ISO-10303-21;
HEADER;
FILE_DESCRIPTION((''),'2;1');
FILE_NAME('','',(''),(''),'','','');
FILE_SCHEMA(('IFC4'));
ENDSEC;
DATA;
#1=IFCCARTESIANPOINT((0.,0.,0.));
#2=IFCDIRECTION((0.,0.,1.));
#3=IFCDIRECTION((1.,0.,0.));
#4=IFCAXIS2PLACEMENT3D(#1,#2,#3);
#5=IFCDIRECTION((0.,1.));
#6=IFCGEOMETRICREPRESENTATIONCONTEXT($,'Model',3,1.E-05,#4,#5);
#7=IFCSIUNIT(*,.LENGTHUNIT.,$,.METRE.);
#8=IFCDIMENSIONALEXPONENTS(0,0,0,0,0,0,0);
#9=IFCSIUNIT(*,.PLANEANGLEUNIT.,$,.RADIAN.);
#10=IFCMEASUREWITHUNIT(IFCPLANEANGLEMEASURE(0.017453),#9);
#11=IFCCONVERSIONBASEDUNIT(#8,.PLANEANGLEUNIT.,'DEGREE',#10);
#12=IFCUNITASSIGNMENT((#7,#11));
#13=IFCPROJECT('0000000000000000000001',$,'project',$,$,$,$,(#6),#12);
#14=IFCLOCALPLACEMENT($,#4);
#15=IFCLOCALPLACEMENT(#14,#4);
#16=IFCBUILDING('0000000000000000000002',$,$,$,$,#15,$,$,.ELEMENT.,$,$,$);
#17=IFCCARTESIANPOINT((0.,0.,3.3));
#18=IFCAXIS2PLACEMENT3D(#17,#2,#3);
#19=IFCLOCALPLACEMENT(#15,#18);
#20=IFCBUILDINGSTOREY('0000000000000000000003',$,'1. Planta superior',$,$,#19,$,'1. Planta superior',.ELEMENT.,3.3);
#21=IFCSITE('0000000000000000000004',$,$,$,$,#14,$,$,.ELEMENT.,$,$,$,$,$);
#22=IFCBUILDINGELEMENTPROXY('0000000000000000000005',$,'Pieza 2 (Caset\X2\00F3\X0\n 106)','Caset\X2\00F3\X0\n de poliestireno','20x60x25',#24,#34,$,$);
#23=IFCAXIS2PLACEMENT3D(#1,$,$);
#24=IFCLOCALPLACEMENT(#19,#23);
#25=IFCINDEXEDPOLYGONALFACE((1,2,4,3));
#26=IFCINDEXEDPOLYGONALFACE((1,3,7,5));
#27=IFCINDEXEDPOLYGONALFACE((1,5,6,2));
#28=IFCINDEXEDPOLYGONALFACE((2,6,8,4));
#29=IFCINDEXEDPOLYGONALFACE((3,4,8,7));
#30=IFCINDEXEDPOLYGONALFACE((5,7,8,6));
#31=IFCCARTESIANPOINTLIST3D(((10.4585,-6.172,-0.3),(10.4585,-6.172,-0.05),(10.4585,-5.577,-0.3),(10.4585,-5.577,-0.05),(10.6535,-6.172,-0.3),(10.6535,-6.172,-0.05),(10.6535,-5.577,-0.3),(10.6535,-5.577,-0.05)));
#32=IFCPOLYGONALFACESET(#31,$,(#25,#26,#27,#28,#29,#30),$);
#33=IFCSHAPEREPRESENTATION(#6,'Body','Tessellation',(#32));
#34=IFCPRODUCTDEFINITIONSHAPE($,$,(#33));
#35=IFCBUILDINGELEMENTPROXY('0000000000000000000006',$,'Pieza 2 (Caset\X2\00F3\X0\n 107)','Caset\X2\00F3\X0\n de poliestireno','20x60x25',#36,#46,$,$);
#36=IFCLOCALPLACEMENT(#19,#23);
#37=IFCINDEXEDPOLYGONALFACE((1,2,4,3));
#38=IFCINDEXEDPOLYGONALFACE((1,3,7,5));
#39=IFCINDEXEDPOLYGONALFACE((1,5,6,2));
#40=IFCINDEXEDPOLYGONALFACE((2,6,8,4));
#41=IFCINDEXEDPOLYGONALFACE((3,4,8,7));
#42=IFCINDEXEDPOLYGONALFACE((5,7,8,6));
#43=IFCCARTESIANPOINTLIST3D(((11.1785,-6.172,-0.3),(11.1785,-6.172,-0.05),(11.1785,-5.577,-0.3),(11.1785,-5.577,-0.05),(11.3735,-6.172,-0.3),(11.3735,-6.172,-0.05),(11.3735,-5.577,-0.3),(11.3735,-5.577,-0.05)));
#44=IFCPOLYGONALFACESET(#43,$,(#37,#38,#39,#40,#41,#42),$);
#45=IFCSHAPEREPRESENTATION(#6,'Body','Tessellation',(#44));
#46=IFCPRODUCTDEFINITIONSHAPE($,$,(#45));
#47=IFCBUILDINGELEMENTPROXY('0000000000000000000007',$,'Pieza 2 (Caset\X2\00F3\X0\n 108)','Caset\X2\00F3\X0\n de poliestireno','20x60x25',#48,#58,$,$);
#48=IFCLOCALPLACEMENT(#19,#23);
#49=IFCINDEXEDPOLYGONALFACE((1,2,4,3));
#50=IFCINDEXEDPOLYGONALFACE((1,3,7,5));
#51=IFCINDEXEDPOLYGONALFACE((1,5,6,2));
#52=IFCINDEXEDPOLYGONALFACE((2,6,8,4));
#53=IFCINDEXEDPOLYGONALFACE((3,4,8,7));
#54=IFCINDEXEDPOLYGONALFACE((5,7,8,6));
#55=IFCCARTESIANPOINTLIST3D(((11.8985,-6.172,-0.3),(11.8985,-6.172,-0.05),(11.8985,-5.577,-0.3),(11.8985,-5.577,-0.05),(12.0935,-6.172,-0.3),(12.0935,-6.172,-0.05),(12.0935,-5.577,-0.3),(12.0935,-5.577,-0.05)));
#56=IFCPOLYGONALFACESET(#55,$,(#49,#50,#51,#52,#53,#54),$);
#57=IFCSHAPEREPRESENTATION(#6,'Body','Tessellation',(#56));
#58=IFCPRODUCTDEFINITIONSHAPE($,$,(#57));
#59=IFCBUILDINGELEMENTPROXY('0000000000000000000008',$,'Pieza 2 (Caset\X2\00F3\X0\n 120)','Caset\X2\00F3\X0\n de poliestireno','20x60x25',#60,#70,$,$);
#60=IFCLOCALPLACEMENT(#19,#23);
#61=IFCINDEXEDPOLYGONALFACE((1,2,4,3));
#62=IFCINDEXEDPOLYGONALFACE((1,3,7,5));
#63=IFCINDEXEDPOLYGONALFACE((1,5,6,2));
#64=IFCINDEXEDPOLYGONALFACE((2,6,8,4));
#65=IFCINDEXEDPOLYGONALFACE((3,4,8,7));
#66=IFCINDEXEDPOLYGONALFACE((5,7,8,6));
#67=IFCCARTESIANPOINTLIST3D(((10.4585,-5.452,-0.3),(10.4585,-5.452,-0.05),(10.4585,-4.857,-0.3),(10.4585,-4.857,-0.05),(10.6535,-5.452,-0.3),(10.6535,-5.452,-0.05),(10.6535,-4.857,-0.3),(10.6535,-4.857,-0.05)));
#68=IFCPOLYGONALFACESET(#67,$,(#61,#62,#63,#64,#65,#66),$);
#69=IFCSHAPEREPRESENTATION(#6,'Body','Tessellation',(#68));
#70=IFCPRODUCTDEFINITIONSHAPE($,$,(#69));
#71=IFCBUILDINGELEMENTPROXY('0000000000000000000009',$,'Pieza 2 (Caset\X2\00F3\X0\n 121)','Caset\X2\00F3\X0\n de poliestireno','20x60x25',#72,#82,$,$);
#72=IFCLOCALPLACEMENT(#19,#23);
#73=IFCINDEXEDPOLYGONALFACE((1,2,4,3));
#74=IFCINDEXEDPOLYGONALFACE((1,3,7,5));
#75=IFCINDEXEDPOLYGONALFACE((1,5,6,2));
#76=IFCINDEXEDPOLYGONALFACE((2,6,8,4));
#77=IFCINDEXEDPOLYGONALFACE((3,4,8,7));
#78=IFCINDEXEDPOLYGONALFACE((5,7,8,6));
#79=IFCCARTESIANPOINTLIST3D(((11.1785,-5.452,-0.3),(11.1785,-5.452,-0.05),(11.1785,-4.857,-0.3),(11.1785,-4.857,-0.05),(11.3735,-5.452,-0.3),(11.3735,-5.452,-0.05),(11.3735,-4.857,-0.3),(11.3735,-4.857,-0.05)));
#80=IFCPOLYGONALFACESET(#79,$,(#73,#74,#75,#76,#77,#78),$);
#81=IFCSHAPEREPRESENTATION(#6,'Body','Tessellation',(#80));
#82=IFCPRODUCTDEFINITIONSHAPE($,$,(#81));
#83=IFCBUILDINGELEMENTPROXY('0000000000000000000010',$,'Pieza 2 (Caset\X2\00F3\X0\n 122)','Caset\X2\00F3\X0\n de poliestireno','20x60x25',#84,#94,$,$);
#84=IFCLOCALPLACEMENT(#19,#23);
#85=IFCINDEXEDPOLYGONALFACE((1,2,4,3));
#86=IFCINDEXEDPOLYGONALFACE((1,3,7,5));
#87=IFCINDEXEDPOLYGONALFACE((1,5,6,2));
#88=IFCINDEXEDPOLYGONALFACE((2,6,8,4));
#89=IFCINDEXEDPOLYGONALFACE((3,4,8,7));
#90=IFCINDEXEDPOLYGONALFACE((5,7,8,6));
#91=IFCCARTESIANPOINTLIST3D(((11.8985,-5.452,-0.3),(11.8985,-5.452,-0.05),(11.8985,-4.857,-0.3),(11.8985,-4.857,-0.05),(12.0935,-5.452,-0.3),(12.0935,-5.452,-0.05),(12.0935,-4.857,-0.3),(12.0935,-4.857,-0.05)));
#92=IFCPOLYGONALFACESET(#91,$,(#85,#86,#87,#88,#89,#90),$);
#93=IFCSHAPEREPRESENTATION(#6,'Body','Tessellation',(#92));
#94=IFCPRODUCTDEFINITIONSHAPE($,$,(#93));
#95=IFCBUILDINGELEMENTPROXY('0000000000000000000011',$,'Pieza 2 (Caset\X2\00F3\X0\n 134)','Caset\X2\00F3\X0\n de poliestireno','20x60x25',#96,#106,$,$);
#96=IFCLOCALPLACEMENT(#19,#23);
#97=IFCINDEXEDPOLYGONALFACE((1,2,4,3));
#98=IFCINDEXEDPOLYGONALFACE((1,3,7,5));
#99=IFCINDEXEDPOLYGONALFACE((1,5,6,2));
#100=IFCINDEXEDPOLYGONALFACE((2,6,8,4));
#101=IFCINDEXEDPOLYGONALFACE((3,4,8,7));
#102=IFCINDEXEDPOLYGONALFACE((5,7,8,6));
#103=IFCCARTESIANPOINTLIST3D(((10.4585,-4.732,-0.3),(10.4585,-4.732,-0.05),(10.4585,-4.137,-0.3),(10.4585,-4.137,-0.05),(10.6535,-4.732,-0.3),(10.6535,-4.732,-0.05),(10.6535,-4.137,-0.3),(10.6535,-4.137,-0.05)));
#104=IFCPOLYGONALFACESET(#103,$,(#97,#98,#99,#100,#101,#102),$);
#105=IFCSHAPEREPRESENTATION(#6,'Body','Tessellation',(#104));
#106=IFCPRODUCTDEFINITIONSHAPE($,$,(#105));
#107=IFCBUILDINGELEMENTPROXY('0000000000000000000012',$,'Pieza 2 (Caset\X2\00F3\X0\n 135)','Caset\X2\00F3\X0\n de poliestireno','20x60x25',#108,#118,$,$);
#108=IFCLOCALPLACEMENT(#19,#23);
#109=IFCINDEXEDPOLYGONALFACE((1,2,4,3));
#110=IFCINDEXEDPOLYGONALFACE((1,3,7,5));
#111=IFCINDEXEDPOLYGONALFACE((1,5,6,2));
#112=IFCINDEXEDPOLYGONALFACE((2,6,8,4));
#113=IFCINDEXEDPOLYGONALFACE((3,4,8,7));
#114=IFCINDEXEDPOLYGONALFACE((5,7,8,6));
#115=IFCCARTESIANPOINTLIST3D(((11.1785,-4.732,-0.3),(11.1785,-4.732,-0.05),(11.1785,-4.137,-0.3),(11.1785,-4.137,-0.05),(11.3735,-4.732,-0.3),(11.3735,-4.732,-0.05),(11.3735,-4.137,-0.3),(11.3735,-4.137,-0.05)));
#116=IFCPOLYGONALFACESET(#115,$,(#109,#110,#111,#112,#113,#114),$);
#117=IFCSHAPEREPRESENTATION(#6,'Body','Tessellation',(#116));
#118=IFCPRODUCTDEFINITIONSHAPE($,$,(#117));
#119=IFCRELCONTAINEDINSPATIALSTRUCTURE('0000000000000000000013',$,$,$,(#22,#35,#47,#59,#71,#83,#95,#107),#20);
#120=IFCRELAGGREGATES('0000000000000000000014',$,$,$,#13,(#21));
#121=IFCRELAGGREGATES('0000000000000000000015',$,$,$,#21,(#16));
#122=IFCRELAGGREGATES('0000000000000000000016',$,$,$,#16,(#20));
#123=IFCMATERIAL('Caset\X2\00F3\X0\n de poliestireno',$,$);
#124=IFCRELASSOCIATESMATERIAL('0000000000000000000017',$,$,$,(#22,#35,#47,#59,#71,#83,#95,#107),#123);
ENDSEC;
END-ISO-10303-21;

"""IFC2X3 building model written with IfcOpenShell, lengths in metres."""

from ifc_helpers import new_model, entity, si_unit, converted_unit, direction, frame, origin_with_axes, origin_2d_with_axis, place, context, project, spatial, rectangle, extrude, source, transform, mapped, material, element, save


model = new_model("IFC2X3")

# Units and contexts
model_context = context("Model", 3, precision=1e-05, world=origin_with_axes(), true_north=direction((0.0, 1.0)))
ifc_project = project(units=[si_unit("LENGTHUNIT", "METRE"), converted_unit("PLANEANGLEUNIT", "DEGREE", entity("IfcPlaneAngleMeasure", 0.017453), si_unit("PLANEANGLEUNIT", "RADIAN"), dimensions=[0, 0, 0, 0, 0, 0, 0])], contexts=[model_context])

# Site, building, storey
site_placement = place(None, origin_with_axes())
site = spatial("IfcSite", under=ifc_project, at=site_placement, CompositionType="ELEMENT")
building_placement = place(site_placement, origin_with_axes())
building = spatial("IfcBuilding", under=site, at=building_placement, CompositionType="ELEMENT")
storey_placement = place(building_placement, frame((0.0, 0.0, 3.3), z_axis=(0.0, 0.0, 1.0), x_axis=(1.0, 0.0, 0.0)))
storey = spatial("IfcBuildingStorey", under=building, at=storey_placement, Name="1. Planta superior", LongName="1. Planta superior", CompositionType="ELEMENT", Elevation=3.3)

# Building element proxies
ifc_material = material(Name="Casetón de poliestireno")
shared_shape = source(origin_with_axes(), model_context, "Body", "SweptSolid", [
    extrude(rectangle(XDim=0.195, YDim=0.25, at=origin_2d_with_axis()), origin_with_axes(), (0.0, 0.0, 1.0), 0.595),
])
placement_1 = place(storey_placement, frame((10.556, -6.172, -0.175), z_axis=(0.0, 1.0, 0.0), x_axis=(-1.0, 0.0, 0.0)))
for number, where, z_axis, x_axis, name in (
    (1, (0.0, 0.0, 0.0), (0.0, 0.0, 1.0), (1.0, 0.0, 0.0), "Pieza 2 (Casetón 106)"),
):
    element("IfcBuildingElementProxy", number, at=place(placement_1, frame(where, z_axis=z_axis, x_axis=x_axis)), inside=storey, material=ifc_material, Name=name, Description="Casetón de poliestireno", ObjectType="20x60x25", context=model_context, shape_type="MappedRepresentation", body=[
        mapped(shared_shape, transform((0.0, 0.0, 0.0), x_axis=(1.0, 0.0, 0.0), y_axis=(0.0, 1.0, 0.0), z_axis=(0.0, 0.0, 1.0))),
    ])
placement_2 = place(storey_placement, frame((11.276, -6.172, -0.175), z_axis=(0.0, 1.0, 0.0), x_axis=(-1.0, 0.0, 0.0)))
for number, where, z_axis, x_axis, name in (
    (2, (0.0, 0.0, 0.0), (0.0, 0.0, 1.0), (1.0, 0.0, 0.0), "Pieza 2 (Casetón 107)"),
):
    element("IfcBuildingElementProxy", number, at=place(placement_2, frame(where, z_axis=z_axis, x_axis=x_axis)), inside=storey, material=ifc_material, Name=name, Description="Casetón de poliestireno", ObjectType="20x60x25", context=model_context, shape_type="MappedRepresentation", body=[
        mapped(shared_shape, transform((0.0, 0.0, 0.0), x_axis=(1.0, 0.0, 0.0), y_axis=(0.0, 1.0, 0.0), z_axis=(0.0, 0.0, 1.0))),
    ])
placement_3 = place(storey_placement, frame((11.996, -6.172, -0.175), z_axis=(0.0, 1.0, 0.0), x_axis=(-1.0, 0.0, 0.0)))
for number, where, z_axis, x_axis, name in (
    (3, (0.0, 0.0, 0.0), (0.0, 0.0, 1.0), (1.0, 0.0, 0.0), "Pieza 2 (Casetón 108)"),
):
    element("IfcBuildingElementProxy", number, at=place(placement_3, frame(where, z_axis=z_axis, x_axis=x_axis)), inside=storey, material=ifc_material, Name=name, Description="Casetón de poliestireno", ObjectType="20x60x25", context=model_context, shape_type="MappedRepresentation", body=[
        mapped(shared_shape, transform((0.0, 0.0, 0.0), x_axis=(1.0, 0.0, 0.0), y_axis=(0.0, 1.0, 0.0), z_axis=(0.0, 0.0, 1.0))),
    ])
placement_4 = place(storey_placement, frame((10.556, -5.452, -0.175), z_axis=(0.0, 1.0, 0.0), x_axis=(-1.0, 0.0, 0.0)))
for number, where, z_axis, x_axis, name in (
    (4, (0.0, 0.0, 0.0), (0.0, 0.0, 1.0), (1.0, 0.0, 0.0), "Pieza 2 (Casetón 120)"),
):
    element("IfcBuildingElementProxy", number, at=place(placement_4, frame(where, z_axis=z_axis, x_axis=x_axis)), inside=storey, material=ifc_material, Name=name, Description="Casetón de poliestireno", ObjectType="20x60x25", context=model_context, shape_type="MappedRepresentation", body=[
        mapped(shared_shape, transform((0.0, 0.0, 0.0), x_axis=(1.0, 0.0, 0.0), y_axis=(0.0, 1.0, 0.0), z_axis=(0.0, 0.0, 1.0))),
    ])
placement_5 = place(storey_placement, frame((11.276, -5.452, -0.175), z_axis=(0.0, 1.0, 0.0), x_axis=(-1.0, 0.0, 0.0)))
for number, where, z_axis, x_axis, name in (
    (5, (0.0, 0.0, 0.0), (0.0, 0.0, 1.0), (1.0, 0.0, 0.0), "Pieza 2 (Casetón 121)"),
):
    element("IfcBuildingElementProxy", number, at=place(placement_5, frame(where, z_axis=z_axis, x_axis=x_axis)), inside=storey, material=ifc_material, Name=name, Description="Casetón de poliestireno", ObjectType="20x60x25", context=model_context, shape_type="MappedRepresentation", body=[
        mapped(shared_shape, transform((0.0, 0.0, 0.0), x_axis=(1.0, 0.0, 0.0), y_axis=(0.0, 1.0, 0.0), z_axis=(0.0, 0.0, 1.0))),
    ])
placement_6 = place(storey_placement, frame((11.996, -5.452, -0.175), z_axis=(0.0, 1.0, 0.0), x_axis=(-1.0, 0.0, 0.0)))
for number, where, z_axis, x_axis, name in (
    (6, (0.0, 0.0, 0.0), (0.0, 0.0, 1.0), (1.0, 0.0, 0.0), "Pieza 2 (Casetón 122)"),
):
    element("IfcBuildingElementProxy", number, at=place(placement_6, frame(where, z_axis=z_axis, x_axis=x_axis)), inside=storey, material=ifc_material, Name=name, Description="Casetón de poliestireno", ObjectType="20x60x25", context=model_context, shape_type="MappedRepresentation", body=[
        mapped(shared_shape, transform((0.0, 0.0, 0.0), x_axis=(1.0, 0.0, 0.0), y_axis=(0.0, 1.0, 0.0), z_axis=(0.0, 0.0, 1.0))),
    ])
placement_7 = place(storey_placement, frame((10.556, -4.732, -0.175), z_axis=(0.0, 1.0, 0.0), x_axis=(-1.0, 0.0, 0.0)))
for number, where, z_axis, x_axis, name in (
    (7, (0.0, 0.0, 0.0), (0.0, 0.0, 1.0), (1.0, 0.0, 0.0), "Pieza 2 (Casetón 134)"),
):
    element("IfcBuildingElementProxy", number, at=place(placement_7, frame(where, z_axis=z_axis, x_axis=x_axis)), inside=storey, material=ifc_material, Name=name, Description="Casetón de poliestireno", ObjectType="20x60x25", context=model_context, shape_type="MappedRepresentation", body=[
        mapped(shared_shape, transform((0.0, 0.0, 0.0), x_axis=(1.0, 0.0, 0.0), y_axis=(0.0, 1.0, 0.0), z_axis=(0.0, 0.0, 1.0))),
    ])
placement_8 = place(storey_placement, frame((11.276, -4.732, -0.175), z_axis=(0.0, 1.0, 0.0), x_axis=(-1.0, 0.0, 0.0)))
for number, where, z_axis, x_axis, name in (
    (8, (0.0, 0.0, 0.0), (0.0, 0.0, 1.0), (1.0, 0.0, 0.0), "Pieza 2 (Casetón 135)"),
):
    element("IfcBuildingElementProxy", number, at=place(placement_8, frame(where, z_axis=z_axis, x_axis=x_axis)), inside=storey, material=ifc_material, Name=name, Description="Casetón de poliestireno", ObjectType="20x60x25", context=model_context, shape_type="MappedRepresentation", body=[
        mapped(shared_shape, transform((0.0, 0.0, 0.0), x_axis=(1.0, 0.0, 0.0), y_axis=(0.0, 1.0, 0.0), z_axis=(0.0, 0.0, 1.0))),
    ])

save(model, "model.ifc")
